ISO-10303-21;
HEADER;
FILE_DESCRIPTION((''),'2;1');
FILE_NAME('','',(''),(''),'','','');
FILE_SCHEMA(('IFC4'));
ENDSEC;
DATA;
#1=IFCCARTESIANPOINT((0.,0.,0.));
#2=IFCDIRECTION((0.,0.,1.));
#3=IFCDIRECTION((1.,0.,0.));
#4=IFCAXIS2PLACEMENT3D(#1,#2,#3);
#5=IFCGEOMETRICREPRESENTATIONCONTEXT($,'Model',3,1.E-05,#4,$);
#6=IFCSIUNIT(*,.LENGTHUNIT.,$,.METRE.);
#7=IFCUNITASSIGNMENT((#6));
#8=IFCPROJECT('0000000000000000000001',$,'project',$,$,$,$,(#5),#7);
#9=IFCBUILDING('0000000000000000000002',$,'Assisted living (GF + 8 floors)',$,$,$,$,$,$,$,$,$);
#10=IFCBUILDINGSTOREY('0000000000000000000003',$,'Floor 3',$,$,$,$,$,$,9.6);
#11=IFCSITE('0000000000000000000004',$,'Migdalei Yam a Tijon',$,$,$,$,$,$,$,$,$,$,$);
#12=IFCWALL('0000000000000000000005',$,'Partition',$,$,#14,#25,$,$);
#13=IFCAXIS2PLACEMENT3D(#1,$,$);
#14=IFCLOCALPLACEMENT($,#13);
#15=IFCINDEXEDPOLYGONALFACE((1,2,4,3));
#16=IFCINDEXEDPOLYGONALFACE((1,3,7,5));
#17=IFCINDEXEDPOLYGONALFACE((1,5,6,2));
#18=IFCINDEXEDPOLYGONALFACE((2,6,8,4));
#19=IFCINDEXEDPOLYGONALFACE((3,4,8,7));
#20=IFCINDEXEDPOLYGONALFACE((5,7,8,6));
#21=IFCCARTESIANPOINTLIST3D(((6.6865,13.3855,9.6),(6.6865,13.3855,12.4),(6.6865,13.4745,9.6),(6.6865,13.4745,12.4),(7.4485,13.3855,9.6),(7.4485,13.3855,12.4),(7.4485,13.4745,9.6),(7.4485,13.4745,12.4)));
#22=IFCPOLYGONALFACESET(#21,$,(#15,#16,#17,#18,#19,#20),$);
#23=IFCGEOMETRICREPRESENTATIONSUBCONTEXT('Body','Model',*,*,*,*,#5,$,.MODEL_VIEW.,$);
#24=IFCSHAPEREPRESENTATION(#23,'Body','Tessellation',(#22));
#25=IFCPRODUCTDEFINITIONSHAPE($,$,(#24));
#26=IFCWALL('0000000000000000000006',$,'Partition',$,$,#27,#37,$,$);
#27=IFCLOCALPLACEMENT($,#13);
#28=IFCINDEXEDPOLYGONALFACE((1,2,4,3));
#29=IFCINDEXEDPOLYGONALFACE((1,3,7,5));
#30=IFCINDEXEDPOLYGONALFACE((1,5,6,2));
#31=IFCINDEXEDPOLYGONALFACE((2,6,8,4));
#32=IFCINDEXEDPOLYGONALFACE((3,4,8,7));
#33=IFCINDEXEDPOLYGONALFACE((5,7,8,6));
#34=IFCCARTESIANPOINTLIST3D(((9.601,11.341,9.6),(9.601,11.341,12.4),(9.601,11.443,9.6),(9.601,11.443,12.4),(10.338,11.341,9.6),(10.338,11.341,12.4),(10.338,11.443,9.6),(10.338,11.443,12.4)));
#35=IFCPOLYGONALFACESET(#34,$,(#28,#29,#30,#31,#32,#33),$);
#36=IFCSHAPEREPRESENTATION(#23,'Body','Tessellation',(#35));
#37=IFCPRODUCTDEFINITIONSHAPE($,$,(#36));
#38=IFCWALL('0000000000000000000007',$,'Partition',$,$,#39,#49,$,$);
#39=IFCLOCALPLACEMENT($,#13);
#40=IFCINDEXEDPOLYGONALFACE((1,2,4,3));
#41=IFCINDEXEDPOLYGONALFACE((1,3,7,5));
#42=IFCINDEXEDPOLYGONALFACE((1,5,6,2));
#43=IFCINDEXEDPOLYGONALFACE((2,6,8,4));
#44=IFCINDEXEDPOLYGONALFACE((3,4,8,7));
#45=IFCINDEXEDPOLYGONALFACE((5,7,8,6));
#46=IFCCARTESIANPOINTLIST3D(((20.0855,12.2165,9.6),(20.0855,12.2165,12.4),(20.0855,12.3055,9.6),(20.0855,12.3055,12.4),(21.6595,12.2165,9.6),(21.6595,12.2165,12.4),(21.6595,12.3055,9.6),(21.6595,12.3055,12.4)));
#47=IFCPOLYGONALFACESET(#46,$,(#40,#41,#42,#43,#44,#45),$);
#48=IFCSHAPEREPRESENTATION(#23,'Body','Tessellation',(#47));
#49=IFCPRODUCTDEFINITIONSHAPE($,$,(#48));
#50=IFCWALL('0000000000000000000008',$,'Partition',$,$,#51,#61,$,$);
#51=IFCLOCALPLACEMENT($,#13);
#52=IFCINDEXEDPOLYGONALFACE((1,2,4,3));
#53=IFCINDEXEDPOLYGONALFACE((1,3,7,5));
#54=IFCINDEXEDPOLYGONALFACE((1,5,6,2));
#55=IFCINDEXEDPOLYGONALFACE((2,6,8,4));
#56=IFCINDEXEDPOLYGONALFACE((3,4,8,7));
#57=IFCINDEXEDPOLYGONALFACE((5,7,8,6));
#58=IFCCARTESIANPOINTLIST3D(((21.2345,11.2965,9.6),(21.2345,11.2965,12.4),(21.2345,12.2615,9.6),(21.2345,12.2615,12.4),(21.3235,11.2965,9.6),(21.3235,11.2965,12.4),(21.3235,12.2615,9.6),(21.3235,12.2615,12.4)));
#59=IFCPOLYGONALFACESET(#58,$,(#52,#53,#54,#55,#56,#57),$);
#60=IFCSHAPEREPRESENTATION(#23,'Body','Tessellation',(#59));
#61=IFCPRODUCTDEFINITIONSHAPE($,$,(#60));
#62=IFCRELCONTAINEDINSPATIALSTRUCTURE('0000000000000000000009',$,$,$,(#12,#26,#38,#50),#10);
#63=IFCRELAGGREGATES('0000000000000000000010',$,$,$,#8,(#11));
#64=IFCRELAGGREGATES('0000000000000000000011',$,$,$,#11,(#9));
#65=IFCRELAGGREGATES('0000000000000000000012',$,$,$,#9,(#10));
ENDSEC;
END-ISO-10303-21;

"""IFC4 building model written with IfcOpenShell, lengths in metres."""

from ifc_helpers import new_model, si_unit, frame, origin_with_axes, context, subcontext, project, spatial, line, indexed_curve, outline, extrude, element, save


model = new_model("IFC4")

# Units and contexts
model_context = context("Model", 3, precision=1e-05, world=origin_with_axes())
body_context = subcontext(model_context, "Body", "Model", "MODEL_VIEW")
ifc_project = project(units=[si_unit("LENGTHUNIT", "METRE")], contexts=[model_context])

# Site, building, storey
site = spatial("IfcSite", under=ifc_project, Name="Migdalei Yam a Tijon")
building = spatial("IfcBuilding", under=site, Name="Assisted living (GF + 8 floors)")
storey = spatial("IfcBuildingStorey", under=building, Name="Floor 3", Elevation=9.6)

# Walls
element("IfcWall", 1, inside=storey, Name="Partition", context=body_context, shape_type="SweptSolid", body=[
    extrude(outline(indexed_curve([(0.0, 0.0), (0.762, 0.0), (0.762, 0.089), (0.0, 0.089)], segments=[line(1, 2, 3, 4, 1)])), frame((6.6865, 13.3855, 9.6), z_axis=(0.0, 0.0, 1.0), x_axis=(1.0, 0.0, 0.0)), (0.0, 0.0, 1.0), 2.8),
])
element("IfcWall", 2, inside=storey, Name="Partition", context=body_context, shape_type="SweptSolid", body=[
    extrude(outline(indexed_curve([(0.0, 0.0), (0.737, 0.0), (0.737, 0.102), (0.0, 0.102)], segments=[line(1, 2, 3, 4, 1)])), frame((9.601, 11.341, 9.6), z_axis=(0.0, 0.0, 1.0), x_axis=(1.0, 0.0, 0.0)), (0.0, 0.0, 1.0), 2.8),
])
element("IfcWall", 3, inside=storey, Name="Partition", context=body_context, shape_type="SweptSolid", body=[
    extrude(outline(indexed_curve([(0.0, 0.0), (1.574, 0.0), (1.574, 0.089), (0.0, 0.089)], segments=[line(1, 2, 3, 4, 1)])), frame((20.0855, 12.2165, 9.6), z_axis=(0.0, 0.0, 1.0), x_axis=(1.0, 0.0, 0.0)), (0.0, 0.0, 1.0), 2.8),
])
element("IfcWall", 4, inside=storey, Name="Partition", context=body_context, shape_type="SweptSolid", body=[
    extrude(outline(indexed_curve([(0.0, 0.0), (0.089, 0.0), (0.089, 0.965), (0.0, 0.965)], segments=[line(1, 2, 3, 4, 1)])), frame((21.2345, 11.2965, 9.6), z_axis=(0.0, 0.0, 1.0), x_axis=(1.0, 0.0, 0.0)), (0.0, 0.0, 1.0), 2.8),
])

save(model, "model.ifc")
